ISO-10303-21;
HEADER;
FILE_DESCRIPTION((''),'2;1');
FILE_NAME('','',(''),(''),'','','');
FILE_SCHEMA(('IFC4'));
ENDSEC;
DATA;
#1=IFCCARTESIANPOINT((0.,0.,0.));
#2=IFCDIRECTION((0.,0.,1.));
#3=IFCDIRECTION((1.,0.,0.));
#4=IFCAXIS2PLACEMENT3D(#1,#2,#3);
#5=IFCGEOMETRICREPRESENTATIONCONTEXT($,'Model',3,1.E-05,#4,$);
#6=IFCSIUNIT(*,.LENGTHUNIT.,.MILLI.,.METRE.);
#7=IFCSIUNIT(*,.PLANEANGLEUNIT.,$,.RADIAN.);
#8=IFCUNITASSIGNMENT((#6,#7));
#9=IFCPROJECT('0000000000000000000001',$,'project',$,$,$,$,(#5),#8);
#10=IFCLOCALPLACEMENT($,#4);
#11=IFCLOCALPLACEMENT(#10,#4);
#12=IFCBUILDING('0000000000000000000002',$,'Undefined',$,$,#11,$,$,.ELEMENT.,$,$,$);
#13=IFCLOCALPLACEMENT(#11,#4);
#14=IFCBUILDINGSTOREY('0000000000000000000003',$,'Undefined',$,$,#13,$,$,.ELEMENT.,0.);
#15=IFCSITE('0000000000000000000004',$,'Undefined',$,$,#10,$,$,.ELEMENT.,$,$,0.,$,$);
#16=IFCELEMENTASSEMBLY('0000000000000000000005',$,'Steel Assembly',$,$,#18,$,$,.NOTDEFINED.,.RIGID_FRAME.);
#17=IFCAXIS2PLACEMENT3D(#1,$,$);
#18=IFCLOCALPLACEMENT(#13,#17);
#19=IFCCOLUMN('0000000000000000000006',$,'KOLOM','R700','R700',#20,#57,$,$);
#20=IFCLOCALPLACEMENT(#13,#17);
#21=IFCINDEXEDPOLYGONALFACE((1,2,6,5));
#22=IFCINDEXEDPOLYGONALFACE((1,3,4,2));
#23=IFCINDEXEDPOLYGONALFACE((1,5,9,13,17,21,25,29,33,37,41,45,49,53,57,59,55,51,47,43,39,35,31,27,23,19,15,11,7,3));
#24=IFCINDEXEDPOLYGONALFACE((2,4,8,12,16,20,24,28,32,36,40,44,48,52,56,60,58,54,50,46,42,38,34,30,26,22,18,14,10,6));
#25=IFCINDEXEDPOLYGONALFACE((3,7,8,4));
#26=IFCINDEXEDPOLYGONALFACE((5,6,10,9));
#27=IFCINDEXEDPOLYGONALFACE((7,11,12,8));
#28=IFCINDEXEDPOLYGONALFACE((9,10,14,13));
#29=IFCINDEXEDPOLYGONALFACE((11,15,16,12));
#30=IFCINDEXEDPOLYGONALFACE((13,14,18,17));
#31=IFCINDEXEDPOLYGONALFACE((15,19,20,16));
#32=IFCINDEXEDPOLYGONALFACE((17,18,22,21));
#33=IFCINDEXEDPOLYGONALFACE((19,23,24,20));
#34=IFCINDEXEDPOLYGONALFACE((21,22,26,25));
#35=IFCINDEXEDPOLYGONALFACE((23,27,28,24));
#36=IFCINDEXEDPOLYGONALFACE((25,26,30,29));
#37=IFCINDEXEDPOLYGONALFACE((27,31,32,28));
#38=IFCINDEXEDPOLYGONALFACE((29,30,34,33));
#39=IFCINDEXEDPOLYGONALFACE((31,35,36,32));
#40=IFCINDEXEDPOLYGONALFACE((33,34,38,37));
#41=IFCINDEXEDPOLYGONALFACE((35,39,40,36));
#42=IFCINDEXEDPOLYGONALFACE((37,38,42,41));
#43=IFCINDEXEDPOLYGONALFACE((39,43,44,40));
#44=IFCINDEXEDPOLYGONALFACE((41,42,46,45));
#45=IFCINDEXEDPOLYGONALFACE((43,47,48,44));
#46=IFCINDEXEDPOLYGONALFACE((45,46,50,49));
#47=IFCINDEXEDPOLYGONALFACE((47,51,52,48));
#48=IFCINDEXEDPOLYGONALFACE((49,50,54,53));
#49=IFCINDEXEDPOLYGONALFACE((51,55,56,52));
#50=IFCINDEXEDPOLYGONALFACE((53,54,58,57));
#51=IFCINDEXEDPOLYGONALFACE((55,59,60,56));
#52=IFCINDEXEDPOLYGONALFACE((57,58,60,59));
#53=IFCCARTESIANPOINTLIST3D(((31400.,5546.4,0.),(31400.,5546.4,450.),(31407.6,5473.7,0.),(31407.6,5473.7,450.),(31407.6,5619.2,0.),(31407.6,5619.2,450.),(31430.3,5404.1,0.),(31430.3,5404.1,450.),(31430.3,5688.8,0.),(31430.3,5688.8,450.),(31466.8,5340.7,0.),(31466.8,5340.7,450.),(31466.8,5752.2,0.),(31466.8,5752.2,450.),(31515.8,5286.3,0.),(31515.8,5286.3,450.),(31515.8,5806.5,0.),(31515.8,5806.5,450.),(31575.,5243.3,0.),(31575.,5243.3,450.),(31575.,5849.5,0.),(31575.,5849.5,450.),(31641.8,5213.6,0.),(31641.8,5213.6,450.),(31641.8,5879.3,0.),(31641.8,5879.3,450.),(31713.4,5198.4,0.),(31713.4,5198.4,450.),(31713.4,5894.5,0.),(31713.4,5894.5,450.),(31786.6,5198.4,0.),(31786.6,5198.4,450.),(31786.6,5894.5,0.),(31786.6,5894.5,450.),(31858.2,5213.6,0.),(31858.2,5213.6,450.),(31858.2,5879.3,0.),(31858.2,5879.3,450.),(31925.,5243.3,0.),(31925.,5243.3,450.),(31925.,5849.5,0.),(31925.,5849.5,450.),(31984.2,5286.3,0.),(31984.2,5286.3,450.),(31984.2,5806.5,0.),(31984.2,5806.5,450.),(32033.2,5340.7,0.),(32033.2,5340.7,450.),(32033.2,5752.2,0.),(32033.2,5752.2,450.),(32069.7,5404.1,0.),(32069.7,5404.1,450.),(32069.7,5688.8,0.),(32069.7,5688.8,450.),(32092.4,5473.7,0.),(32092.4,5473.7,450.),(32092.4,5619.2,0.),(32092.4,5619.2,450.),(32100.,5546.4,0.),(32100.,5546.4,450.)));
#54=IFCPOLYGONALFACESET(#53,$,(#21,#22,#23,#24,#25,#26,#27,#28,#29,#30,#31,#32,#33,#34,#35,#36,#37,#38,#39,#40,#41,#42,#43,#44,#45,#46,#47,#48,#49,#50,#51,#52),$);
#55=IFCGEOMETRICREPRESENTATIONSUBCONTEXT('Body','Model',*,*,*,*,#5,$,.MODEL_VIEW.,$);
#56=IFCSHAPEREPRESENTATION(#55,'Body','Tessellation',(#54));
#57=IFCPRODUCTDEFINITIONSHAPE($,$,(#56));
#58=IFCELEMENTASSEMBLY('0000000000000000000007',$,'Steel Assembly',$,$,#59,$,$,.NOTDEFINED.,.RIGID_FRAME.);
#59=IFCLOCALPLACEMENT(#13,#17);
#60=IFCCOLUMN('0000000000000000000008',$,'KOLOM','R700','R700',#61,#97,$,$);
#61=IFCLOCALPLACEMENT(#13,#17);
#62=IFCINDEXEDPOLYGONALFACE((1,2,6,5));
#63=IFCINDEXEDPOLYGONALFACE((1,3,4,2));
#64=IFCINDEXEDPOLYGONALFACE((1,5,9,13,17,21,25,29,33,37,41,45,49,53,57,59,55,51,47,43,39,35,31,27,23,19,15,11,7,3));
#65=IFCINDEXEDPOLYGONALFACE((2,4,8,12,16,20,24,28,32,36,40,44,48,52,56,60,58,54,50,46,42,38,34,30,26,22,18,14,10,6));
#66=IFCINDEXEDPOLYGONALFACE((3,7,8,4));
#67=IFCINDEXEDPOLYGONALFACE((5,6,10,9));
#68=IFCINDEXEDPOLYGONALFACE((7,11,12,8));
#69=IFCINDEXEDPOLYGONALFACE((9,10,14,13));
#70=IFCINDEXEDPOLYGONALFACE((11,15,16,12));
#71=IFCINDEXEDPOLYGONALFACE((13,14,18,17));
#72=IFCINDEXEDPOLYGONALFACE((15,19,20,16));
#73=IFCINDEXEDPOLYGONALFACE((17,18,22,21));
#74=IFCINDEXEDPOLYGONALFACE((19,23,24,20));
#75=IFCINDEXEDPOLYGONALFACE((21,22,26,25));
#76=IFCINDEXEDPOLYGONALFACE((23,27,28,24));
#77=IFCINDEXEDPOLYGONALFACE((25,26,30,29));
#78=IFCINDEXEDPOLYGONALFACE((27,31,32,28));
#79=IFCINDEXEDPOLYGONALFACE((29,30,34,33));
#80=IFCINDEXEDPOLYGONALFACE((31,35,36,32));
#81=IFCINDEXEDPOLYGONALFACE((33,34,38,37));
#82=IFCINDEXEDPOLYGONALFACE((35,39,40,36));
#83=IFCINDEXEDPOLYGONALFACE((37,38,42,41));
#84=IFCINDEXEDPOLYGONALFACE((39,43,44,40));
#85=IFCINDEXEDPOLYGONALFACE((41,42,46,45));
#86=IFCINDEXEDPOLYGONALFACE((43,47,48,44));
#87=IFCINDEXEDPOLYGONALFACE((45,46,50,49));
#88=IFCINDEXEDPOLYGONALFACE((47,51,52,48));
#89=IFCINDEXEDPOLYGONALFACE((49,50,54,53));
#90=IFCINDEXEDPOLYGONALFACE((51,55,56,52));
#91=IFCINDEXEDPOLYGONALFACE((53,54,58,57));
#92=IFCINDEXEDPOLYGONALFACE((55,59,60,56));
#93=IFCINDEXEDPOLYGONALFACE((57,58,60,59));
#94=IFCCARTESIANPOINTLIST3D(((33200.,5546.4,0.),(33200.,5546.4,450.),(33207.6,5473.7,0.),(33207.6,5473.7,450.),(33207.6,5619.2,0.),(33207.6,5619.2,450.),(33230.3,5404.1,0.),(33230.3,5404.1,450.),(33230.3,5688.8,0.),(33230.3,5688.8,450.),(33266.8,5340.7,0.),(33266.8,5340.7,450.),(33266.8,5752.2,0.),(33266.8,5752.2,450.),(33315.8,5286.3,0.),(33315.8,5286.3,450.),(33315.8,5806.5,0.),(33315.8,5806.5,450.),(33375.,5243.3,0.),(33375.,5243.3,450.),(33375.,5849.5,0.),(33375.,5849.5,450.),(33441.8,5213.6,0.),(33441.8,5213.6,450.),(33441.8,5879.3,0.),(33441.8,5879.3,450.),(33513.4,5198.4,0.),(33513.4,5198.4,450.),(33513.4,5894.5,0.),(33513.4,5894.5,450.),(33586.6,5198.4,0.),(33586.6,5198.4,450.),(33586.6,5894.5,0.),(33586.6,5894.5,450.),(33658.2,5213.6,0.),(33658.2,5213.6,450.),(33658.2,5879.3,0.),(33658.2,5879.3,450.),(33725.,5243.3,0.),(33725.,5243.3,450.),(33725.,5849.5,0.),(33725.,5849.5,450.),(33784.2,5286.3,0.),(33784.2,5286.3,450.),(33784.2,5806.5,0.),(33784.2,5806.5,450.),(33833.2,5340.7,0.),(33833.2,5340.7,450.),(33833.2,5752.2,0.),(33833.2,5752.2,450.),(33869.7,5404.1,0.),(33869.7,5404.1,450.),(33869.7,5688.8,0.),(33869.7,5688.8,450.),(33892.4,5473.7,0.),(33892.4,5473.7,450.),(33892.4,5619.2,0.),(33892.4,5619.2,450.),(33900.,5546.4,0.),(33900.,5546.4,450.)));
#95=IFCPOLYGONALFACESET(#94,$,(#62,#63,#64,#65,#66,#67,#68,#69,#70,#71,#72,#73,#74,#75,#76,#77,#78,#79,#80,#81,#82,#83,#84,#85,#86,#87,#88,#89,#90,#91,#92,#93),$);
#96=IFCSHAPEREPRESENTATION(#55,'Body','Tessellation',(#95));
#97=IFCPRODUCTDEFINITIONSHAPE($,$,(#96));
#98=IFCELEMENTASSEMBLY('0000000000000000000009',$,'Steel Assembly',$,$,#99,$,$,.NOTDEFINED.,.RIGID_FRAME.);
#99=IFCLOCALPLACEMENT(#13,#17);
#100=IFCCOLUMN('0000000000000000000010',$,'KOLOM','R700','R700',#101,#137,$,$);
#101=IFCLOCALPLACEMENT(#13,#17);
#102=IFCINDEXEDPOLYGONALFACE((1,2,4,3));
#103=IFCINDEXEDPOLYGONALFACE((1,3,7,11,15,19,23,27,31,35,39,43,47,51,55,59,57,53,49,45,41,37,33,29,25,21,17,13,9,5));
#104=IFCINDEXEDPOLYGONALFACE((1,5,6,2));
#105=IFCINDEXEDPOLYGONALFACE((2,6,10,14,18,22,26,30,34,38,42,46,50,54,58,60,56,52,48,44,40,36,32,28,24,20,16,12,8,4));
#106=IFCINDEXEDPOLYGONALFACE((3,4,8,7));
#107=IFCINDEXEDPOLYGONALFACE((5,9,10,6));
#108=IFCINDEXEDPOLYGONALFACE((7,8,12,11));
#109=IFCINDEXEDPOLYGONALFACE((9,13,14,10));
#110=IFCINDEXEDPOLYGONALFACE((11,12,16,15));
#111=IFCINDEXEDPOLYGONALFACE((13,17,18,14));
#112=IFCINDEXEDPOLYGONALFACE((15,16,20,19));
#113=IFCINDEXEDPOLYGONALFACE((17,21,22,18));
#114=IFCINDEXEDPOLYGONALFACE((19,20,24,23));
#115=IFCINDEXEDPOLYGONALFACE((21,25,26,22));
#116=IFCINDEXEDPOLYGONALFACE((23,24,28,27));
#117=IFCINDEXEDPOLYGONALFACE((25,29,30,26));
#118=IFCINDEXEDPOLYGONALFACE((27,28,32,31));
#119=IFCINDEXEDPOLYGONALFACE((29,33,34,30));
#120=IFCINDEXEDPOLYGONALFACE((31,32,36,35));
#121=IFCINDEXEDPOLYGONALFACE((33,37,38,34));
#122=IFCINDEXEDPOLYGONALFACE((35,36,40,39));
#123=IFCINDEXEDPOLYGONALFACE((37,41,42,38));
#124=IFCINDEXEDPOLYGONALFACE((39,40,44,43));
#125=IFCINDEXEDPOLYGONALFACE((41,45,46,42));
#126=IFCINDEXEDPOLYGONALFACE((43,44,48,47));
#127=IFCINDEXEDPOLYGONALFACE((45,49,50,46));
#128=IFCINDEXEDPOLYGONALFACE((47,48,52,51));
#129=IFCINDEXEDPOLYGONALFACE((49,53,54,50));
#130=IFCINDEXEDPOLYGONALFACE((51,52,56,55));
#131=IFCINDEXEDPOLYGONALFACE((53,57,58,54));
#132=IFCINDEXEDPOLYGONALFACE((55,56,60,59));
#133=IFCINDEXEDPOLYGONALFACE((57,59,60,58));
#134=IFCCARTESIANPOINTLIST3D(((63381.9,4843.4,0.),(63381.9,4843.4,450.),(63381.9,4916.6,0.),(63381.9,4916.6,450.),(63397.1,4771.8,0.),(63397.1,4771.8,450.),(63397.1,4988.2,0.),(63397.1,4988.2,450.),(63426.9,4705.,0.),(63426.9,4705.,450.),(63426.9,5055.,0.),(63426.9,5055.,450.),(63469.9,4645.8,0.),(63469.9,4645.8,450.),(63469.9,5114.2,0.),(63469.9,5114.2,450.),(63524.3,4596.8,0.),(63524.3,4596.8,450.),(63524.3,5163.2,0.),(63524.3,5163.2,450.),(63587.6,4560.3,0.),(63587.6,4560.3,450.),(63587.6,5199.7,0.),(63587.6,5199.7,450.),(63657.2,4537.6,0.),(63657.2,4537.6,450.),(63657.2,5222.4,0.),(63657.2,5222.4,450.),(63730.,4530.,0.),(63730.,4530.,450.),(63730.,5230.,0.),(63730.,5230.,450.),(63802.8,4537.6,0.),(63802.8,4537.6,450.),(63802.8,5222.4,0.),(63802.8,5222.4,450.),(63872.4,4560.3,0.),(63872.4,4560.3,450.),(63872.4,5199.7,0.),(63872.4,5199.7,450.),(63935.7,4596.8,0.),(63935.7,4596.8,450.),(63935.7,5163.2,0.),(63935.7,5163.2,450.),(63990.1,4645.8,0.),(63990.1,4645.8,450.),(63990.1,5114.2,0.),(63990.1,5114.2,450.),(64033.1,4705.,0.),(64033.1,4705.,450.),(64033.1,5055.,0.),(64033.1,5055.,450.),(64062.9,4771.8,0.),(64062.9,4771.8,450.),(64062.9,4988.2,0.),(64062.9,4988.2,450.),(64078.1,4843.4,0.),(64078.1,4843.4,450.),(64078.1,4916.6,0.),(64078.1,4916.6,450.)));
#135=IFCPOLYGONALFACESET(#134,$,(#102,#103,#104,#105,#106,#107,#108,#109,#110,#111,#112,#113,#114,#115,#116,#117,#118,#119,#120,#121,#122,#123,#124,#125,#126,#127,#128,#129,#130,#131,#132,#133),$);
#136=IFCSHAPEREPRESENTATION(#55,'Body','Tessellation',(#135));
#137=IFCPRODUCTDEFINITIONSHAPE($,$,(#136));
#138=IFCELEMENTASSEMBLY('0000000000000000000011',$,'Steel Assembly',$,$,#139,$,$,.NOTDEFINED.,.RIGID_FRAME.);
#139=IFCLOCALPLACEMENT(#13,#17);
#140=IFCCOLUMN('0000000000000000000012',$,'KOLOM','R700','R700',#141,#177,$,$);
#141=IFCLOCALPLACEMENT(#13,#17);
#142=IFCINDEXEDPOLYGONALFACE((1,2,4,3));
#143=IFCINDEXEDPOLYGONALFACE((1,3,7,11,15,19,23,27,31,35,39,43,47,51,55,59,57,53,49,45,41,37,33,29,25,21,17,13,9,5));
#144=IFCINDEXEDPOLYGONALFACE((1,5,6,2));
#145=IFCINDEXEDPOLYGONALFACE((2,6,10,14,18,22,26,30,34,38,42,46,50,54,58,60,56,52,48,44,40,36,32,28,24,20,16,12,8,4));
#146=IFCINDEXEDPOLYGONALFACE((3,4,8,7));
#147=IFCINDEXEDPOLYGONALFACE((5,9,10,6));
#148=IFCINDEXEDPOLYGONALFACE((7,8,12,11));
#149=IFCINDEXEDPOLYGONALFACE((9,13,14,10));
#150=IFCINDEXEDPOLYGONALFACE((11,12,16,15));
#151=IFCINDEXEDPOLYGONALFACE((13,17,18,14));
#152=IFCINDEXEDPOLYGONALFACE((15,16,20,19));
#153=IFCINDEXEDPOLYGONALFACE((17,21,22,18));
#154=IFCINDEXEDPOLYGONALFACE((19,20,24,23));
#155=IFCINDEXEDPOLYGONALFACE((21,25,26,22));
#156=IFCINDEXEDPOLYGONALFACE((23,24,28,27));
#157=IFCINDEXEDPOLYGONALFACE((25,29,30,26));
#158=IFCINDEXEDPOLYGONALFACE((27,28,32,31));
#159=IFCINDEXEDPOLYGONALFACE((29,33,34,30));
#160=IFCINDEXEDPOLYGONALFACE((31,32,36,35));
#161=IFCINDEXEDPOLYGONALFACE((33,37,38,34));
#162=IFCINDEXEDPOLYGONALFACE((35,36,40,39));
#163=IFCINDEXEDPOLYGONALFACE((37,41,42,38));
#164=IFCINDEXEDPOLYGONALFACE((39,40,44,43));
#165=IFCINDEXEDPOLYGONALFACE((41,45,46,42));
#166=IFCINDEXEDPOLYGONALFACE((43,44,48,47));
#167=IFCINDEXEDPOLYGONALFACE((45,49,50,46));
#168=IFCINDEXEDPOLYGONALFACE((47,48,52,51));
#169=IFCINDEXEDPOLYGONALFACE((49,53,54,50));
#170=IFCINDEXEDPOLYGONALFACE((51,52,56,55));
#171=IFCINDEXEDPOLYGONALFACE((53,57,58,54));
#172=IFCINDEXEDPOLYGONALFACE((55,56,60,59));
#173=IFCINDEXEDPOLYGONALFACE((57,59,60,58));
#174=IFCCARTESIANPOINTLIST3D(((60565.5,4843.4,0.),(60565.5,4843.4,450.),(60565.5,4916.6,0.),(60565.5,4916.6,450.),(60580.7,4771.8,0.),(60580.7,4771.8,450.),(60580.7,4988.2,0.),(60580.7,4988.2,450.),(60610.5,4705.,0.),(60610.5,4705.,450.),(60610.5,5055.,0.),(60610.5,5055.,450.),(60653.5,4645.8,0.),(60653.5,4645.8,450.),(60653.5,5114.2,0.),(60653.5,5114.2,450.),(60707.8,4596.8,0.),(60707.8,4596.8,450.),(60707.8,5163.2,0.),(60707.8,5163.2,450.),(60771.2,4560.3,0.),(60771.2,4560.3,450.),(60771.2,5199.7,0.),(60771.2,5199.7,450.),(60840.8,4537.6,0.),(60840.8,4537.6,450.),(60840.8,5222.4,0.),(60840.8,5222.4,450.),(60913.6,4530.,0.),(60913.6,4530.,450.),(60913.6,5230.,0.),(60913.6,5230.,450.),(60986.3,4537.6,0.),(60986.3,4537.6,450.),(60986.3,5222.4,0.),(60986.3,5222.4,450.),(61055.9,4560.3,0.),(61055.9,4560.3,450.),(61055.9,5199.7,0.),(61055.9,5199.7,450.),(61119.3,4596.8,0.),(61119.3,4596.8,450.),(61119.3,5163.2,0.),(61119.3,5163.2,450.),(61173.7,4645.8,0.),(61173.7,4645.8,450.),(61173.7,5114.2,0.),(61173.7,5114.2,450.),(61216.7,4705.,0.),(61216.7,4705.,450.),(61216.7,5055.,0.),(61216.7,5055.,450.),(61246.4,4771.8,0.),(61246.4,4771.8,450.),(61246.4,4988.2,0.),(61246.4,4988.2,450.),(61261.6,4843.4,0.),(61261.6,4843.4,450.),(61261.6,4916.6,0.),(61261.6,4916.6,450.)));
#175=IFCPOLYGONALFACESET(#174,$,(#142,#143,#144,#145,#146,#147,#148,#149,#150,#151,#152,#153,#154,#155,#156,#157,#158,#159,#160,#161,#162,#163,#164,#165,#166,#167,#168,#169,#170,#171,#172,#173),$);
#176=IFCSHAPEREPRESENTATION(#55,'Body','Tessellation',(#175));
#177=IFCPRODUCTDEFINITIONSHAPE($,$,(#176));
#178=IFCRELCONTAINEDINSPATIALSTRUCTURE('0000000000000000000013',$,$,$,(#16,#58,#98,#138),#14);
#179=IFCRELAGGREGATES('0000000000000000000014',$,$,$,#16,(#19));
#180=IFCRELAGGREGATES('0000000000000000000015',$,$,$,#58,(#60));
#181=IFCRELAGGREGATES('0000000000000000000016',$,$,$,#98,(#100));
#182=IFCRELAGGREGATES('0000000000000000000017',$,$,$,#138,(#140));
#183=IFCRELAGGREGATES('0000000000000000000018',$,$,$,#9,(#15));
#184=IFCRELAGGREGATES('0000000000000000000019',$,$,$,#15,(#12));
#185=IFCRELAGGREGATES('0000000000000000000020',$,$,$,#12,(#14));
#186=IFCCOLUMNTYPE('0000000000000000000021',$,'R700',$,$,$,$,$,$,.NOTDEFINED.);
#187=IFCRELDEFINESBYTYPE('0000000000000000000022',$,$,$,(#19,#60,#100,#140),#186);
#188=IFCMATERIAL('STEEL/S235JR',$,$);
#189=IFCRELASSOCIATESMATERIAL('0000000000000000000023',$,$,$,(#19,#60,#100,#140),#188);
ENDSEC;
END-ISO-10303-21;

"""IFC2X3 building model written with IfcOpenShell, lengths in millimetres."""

from ifc_helpers import new_model, si_unit, frame, origin_with_axes, origin_2d_with_axis, place, context, subcontext, project, spatial, circle, extrude, material, type_object, element, aggregate, save


model = new_model("IFC2X3")

# Units and contexts
model_context = context("Model", 3, precision=1e-05, world=origin_with_axes())
body_context = subcontext(model_context, "Body", "Model", "MODEL_VIEW")
ifc_project = project(units=[si_unit("LENGTHUNIT", "METRE", prefix="MILLI"), si_unit("PLANEANGLEUNIT", "RADIAN")], contexts=[model_context])

# Site, building, storey
site_placement = place(None, origin_with_axes())
site = spatial("IfcSite", under=ifc_project, at=site_placement, Name="Undefined", CompositionType="ELEMENT", RefElevation=0.0)
building_placement = place(site_placement, origin_with_axes())
building = spatial("IfcBuilding", under=site, at=building_placement, Name="Undefined", CompositionType="ELEMENT")
storey_placement = place(building_placement, origin_with_axes())
storey = spatial("IfcBuildingStorey", under=building, at=storey_placement, Name="Undefined", CompositionType="ELEMENT", Elevation=0.0)

# Element assemblies, columns
ifc_material = material(Name="STEEL/S235JR")
column_type = type_object("IfcColumnType", Name="R700", PredefinedType="NOTDEFINED")
assembly_1_placement = place(storey_placement, origin_with_axes())
assembly_1 = element("IfcElementAssembly", 1, at=assembly_1_placement, inside=storey, Name="Steel Assembly", AssemblyPlace="NOTDEFINED", PredefinedType="RIGID_FRAME")
column_1_placement = place(assembly_1_placement, frame((31750.0, 5546.4, 450.0), z_axis=(0.0, 0.0, -1.0), x_axis=(0.0, 1.0, 0.0)))
column_1 = element("IfcColumn", 2, at=column_1_placement, type_object=column_type, material=ifc_material, Name="KOLOM", Description="R700", ObjectType="R700", context=body_context, shape_type="SweptSolid", body=[
    extrude(circle(Radius=350.0, at=origin_2d_with_axis()), frame((0.0, 0.0, 450.0), z_axis=(0.0, 0.0, -1.0), x_axis=(0.0, 1.0, 0.0)), (0.0, 0.0, 1.0), 450.0),
])
aggregate(assembly_1, [column_1])
assembly_2_placement = place(storey_placement, origin_with_axes())
assembly_2 = element("IfcElementAssembly", 3, at=assembly_2_placement, inside=storey, Name="Steel Assembly", AssemblyPlace="NOTDEFINED", PredefinedType="RIGID_FRAME")
column_2_placement = place(assembly_2_placement, frame((33550.0, 5546.4, 450.0), z_axis=(0.0, 0.0, -1.0), x_axis=(0.0, 1.0, 0.0)))
column_2 = element("IfcColumn", 4, at=column_2_placement, type_object=column_type, material=ifc_material, Name="KOLOM", Description="R700", ObjectType="R700", context=body_context, shape_type="SweptSolid", body=[
    extrude(circle(Radius=350.0, at=origin_2d_with_axis()), frame((0.0, 0.0, 450.0), z_axis=(0.0, 0.0, -1.0), x_axis=(0.0, 1.0, 0.0)), (0.0, 0.0, 1.0), 450.0),
])
aggregate(assembly_2, [column_2])
assembly_3_placement = place(storey_placement, origin_with_axes())
assembly_3 = element("IfcElementAssembly", 5, at=assembly_3_placement, inside=storey, Name="Steel Assembly", AssemblyPlace="NOTDEFINED", PredefinedType="RIGID_FRAME")
column_3_placement = place(assembly_3_placement, frame((63730.0, 4880.0, 0.0), z_axis=(0.0, 0.0, 1.0), x_axis=(-1.0, 0.0, 0.0)))
column_3 = element("IfcColumn", 6, at=column_3_placement, type_object=column_type, material=ifc_material, Name="KOLOM", Description="R700", ObjectType="R700", context=body_context, shape_type="SweptSolid", body=[
    extrude(circle(Radius=350.0, at=origin_2d_with_axis()), frame((0.0, 0.0, 450.0), z_axis=(0.0, 0.0, -1.0), x_axis=(0.0, 1.0, 0.0)), (0.0, 0.0, 1.0), 450.0),
])
aggregate(assembly_3, [column_3])
assembly_4_placement = place(storey_placement, origin_with_axes())
assembly_4 = element("IfcElementAssembly", 7, at=assembly_4_placement, inside=storey, Name="Steel Assembly", AssemblyPlace="NOTDEFINED", PredefinedType="RIGID_FRAME")
column_4_placement = place(assembly_4_placement, frame((60913.6, 4880.0, 0.0), z_axis=(0.0, 0.0, 1.0), x_axis=(-1.0, 0.0, 0.0)))
column_4 = element("IfcColumn", 8, at=column_4_placement, type_object=column_type, material=ifc_material, Name="KOLOM", Description="R700", ObjectType="R700", context=body_context, shape_type="SweptSolid", body=[
    extrude(circle(Radius=350.0, at=origin_2d_with_axis()), frame((0.0, 0.0, 450.0), z_axis=(0.0, 0.0, -1.0), x_axis=(0.0, 1.0, 0.0)), (0.0, 0.0, 1.0), 450.0),
])
aggregate(assembly_4, [column_4])

save(model, "model.ifc")
